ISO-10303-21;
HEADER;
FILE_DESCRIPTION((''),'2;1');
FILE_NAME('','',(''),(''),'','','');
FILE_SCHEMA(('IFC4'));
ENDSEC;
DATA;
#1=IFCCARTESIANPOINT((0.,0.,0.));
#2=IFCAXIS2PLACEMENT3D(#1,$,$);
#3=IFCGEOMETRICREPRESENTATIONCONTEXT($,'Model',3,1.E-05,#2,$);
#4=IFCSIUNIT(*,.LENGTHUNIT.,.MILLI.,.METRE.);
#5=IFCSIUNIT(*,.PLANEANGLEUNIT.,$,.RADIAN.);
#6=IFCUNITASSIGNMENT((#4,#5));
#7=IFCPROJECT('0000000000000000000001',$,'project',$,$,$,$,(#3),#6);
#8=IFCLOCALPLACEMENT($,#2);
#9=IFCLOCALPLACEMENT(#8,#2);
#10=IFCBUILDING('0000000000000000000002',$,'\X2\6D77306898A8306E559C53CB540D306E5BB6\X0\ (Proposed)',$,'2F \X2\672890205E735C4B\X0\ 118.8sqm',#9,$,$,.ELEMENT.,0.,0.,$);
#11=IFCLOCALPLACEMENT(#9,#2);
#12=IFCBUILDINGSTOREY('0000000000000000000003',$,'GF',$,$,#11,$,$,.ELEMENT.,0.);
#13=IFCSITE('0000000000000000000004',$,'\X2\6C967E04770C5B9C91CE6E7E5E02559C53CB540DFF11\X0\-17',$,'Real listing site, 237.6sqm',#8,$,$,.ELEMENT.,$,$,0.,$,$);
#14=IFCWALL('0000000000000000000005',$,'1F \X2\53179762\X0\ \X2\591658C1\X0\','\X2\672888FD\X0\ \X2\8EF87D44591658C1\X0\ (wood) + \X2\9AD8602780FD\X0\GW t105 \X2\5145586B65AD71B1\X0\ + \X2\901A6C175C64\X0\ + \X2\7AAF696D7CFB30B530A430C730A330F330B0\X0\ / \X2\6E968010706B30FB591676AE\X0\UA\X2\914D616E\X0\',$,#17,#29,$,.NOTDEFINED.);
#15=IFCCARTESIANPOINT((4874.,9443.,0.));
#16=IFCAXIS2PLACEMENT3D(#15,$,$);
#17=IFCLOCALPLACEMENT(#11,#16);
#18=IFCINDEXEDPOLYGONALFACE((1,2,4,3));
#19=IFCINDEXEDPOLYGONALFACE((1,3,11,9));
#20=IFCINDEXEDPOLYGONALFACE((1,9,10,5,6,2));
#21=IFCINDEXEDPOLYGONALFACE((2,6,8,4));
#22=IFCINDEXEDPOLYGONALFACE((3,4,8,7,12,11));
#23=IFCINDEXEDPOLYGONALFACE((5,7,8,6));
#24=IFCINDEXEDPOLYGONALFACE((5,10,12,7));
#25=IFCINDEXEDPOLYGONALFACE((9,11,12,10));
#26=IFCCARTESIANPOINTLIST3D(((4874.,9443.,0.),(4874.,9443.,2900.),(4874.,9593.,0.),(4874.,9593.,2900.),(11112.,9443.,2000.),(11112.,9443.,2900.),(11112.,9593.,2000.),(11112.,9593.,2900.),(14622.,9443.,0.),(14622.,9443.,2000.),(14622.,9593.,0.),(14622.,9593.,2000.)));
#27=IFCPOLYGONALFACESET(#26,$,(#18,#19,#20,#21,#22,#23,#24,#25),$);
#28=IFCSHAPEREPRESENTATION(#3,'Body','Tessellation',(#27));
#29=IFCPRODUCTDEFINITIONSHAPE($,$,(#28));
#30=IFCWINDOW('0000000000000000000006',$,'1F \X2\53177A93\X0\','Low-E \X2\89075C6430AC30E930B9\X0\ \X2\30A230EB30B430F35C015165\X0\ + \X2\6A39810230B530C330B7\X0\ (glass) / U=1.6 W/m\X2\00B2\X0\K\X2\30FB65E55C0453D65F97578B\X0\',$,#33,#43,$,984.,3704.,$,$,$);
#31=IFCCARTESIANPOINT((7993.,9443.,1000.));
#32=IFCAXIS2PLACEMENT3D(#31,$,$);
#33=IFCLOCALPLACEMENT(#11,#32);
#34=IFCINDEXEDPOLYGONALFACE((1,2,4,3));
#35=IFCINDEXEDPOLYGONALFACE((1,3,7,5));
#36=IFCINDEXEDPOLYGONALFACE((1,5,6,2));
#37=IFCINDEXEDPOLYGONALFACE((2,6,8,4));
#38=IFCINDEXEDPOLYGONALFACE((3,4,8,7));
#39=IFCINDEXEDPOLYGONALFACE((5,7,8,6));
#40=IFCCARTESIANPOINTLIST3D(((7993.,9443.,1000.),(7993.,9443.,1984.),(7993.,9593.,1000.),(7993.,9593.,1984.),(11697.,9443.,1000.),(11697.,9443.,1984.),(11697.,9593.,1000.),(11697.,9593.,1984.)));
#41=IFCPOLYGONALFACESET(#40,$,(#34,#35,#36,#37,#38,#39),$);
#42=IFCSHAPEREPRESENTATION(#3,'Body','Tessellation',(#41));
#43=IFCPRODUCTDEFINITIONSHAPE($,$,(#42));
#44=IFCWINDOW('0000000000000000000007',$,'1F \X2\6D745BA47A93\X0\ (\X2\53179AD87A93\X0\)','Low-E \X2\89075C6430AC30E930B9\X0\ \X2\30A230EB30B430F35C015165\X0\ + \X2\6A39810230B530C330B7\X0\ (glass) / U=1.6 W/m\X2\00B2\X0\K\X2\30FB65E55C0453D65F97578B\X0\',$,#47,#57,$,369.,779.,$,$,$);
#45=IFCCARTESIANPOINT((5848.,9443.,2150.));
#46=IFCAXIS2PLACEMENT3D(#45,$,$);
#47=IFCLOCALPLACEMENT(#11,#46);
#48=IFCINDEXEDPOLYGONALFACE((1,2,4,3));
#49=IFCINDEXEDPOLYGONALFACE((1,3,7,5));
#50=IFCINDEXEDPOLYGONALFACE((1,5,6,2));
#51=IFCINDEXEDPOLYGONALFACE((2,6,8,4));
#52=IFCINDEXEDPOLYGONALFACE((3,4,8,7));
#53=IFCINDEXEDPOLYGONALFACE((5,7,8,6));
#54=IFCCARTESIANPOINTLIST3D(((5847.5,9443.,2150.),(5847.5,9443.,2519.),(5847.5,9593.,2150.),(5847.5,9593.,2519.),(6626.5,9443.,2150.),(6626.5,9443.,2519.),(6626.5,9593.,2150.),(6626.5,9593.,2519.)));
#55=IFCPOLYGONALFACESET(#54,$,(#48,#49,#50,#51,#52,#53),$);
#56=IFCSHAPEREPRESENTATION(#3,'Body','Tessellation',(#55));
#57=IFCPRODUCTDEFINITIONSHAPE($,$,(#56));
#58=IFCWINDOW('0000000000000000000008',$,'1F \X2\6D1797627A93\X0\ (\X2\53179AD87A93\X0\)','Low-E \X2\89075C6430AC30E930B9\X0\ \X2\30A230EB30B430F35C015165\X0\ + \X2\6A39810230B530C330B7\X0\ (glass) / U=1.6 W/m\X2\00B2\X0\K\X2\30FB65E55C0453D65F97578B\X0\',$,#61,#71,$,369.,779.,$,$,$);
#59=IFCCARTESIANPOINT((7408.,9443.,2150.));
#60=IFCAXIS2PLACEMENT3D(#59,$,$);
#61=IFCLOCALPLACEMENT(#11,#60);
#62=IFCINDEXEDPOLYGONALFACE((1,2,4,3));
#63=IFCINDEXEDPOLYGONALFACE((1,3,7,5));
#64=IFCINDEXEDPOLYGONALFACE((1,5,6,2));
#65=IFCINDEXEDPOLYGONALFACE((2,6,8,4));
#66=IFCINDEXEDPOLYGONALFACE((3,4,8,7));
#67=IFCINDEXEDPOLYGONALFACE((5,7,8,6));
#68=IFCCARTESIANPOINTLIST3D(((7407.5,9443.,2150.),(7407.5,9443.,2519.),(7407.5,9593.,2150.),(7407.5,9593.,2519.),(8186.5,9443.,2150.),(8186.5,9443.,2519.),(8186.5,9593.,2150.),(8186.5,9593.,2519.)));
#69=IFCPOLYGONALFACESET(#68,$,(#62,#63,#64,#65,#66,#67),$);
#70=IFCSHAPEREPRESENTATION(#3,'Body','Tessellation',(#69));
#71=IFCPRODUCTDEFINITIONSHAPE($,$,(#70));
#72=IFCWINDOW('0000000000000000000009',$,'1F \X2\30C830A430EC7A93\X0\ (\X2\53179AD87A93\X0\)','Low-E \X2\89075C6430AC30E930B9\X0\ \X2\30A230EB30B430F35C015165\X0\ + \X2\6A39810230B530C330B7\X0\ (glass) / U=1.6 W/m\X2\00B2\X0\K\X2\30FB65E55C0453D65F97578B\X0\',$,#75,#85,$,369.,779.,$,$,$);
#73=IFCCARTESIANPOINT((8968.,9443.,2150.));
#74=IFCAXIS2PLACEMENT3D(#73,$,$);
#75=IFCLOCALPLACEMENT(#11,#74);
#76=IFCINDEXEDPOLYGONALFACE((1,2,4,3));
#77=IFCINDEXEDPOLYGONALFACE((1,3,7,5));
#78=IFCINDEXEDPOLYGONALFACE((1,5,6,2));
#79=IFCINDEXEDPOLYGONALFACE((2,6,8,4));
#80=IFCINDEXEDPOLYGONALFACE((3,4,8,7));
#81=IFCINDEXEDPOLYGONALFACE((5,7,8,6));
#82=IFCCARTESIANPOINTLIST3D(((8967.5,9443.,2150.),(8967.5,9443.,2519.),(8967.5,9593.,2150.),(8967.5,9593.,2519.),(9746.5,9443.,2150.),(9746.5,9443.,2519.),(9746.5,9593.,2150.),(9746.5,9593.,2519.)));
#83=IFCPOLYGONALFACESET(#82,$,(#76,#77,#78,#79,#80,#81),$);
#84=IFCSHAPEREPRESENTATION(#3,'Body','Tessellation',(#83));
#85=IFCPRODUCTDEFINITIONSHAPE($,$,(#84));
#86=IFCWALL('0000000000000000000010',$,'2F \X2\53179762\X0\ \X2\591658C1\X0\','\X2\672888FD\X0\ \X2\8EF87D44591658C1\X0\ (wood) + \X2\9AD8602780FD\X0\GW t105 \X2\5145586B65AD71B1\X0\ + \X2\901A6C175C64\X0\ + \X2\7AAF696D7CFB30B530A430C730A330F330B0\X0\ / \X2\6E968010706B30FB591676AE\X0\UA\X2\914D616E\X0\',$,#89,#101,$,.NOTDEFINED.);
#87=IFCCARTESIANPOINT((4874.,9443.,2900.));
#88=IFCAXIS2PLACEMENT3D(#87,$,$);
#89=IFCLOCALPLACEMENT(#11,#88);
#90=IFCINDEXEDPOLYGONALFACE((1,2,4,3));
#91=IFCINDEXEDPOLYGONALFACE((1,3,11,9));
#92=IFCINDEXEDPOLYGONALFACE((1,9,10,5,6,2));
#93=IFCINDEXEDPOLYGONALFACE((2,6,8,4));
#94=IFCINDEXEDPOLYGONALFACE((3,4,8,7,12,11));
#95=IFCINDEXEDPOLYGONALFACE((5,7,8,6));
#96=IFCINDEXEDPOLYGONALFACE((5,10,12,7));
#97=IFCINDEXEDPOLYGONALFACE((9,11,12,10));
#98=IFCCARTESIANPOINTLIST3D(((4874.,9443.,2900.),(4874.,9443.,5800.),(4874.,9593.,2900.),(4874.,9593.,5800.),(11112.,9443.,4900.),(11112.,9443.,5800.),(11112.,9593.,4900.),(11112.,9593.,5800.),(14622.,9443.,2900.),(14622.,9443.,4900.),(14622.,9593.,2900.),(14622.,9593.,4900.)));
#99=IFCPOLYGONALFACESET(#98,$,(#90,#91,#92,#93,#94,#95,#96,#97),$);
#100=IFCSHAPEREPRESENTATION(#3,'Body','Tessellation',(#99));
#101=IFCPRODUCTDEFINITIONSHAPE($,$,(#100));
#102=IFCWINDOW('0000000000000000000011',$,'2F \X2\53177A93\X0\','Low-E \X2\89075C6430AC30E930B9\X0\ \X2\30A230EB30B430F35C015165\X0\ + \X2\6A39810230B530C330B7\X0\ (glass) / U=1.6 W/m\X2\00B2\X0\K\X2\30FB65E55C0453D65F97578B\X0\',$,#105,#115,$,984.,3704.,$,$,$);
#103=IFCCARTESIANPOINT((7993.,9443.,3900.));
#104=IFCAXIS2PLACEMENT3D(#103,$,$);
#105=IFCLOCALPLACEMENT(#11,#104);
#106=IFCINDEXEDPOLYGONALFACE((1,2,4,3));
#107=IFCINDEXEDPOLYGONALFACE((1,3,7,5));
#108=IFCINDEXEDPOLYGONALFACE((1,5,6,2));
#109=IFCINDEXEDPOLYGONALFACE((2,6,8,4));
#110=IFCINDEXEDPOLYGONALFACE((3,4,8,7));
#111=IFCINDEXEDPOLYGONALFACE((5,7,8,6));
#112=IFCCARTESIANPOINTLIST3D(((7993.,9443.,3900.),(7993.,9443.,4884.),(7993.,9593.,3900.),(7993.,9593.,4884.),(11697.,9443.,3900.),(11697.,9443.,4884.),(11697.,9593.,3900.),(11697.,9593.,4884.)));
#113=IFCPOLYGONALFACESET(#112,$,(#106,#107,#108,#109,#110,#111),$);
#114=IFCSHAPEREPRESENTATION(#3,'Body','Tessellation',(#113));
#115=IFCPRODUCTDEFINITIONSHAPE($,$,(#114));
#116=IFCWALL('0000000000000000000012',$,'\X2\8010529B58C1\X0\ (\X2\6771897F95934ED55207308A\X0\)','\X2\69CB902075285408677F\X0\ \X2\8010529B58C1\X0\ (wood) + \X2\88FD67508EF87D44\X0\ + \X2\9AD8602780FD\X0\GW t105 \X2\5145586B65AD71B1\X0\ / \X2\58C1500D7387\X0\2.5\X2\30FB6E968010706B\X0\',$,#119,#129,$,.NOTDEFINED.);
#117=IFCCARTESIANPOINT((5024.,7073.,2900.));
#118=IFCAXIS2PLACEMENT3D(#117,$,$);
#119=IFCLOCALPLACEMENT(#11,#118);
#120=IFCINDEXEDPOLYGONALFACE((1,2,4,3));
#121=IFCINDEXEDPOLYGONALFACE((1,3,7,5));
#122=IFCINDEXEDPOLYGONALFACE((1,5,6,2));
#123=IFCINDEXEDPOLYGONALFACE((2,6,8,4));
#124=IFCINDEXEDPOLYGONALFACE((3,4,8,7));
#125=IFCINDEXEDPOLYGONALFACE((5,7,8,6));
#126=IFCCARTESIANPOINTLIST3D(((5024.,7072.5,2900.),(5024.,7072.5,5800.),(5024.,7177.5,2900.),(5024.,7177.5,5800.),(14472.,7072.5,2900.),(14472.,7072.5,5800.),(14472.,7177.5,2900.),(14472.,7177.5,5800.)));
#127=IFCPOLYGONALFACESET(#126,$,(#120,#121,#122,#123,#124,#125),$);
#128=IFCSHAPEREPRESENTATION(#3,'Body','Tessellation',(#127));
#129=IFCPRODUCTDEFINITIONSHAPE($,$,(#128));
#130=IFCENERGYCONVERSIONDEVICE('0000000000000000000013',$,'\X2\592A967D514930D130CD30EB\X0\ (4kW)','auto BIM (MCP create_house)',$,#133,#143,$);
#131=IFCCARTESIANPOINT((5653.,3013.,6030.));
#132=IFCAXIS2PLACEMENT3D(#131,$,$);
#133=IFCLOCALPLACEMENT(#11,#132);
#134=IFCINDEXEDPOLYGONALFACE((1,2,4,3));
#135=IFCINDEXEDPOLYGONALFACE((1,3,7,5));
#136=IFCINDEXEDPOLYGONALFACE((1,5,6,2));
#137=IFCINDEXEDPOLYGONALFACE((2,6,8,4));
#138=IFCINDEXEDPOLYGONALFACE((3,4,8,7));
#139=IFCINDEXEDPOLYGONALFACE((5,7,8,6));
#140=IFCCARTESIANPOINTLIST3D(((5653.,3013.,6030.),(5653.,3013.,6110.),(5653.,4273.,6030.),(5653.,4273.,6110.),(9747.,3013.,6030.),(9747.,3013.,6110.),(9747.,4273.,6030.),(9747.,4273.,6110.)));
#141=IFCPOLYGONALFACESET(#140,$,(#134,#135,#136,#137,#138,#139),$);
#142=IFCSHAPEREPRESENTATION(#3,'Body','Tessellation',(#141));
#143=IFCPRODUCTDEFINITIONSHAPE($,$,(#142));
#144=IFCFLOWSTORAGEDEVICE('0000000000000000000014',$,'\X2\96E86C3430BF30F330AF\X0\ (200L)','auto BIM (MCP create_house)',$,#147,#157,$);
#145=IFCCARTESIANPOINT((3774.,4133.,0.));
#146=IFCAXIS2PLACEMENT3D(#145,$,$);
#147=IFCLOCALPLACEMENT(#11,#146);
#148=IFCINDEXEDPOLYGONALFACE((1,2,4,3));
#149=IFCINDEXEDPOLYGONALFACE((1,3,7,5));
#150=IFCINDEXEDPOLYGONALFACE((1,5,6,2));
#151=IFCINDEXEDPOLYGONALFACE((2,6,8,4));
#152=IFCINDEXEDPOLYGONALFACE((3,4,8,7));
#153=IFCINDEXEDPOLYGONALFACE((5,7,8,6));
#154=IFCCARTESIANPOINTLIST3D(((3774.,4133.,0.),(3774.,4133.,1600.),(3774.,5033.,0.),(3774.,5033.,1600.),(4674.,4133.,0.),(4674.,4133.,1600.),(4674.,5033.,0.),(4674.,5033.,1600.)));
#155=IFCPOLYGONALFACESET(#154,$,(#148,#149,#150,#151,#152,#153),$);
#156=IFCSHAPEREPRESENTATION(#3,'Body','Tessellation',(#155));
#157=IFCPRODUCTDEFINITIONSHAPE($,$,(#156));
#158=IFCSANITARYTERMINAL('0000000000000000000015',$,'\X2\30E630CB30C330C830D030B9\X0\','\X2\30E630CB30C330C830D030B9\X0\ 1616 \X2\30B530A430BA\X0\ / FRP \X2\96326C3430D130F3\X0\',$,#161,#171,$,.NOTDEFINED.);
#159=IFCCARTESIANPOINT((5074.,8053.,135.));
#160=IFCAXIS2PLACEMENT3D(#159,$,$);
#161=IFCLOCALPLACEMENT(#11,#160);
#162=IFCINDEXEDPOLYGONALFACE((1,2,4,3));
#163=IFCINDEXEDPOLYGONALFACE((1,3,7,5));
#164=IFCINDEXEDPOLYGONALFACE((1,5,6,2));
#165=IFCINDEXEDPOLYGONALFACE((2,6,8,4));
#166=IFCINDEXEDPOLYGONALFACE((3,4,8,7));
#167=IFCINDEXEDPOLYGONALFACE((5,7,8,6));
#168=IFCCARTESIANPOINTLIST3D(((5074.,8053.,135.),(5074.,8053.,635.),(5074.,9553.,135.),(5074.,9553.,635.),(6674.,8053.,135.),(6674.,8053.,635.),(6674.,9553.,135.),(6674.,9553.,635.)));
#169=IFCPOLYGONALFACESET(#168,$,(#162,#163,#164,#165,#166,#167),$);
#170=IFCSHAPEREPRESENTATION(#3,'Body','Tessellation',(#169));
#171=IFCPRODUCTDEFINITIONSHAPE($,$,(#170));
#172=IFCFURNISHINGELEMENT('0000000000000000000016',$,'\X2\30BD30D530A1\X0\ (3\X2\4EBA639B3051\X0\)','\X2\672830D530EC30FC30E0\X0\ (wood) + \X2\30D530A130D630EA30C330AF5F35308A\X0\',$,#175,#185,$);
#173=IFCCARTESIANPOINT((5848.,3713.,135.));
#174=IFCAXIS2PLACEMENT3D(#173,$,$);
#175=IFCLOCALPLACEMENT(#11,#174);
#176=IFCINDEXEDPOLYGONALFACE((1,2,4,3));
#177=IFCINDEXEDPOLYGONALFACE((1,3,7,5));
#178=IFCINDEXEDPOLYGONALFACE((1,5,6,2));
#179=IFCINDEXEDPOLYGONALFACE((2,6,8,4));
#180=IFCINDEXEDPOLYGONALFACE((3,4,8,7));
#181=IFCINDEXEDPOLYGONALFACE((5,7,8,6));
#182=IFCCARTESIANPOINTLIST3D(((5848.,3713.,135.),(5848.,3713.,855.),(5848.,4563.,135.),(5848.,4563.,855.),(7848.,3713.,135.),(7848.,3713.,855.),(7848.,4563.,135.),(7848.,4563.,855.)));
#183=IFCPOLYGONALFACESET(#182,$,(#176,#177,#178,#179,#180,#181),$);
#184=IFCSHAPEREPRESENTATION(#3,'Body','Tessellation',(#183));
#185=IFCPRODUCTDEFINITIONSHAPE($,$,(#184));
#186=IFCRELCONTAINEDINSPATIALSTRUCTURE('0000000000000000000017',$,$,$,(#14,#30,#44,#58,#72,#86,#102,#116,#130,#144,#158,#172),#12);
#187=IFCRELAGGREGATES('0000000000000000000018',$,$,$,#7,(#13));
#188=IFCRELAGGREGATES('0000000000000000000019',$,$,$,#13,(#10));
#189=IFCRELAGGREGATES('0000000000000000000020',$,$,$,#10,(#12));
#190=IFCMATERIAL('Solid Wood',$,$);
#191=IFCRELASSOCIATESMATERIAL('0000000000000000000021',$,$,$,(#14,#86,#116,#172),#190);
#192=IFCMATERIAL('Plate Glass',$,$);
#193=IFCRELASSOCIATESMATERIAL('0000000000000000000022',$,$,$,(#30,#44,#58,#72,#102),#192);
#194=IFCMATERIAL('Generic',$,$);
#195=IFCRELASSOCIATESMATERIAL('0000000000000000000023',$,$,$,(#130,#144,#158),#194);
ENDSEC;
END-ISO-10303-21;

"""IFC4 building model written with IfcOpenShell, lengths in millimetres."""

from ifc_helpers import new_model, si_unit, frame, frame_2d, origin, place, context, project, spatial, rectangle, extrude, material, element, fill, save


model = new_model("IFC4")

# Units and contexts
model_context = context("Model", 3, precision=1e-05, world=origin())
ifc_project = project(units=[si_unit("LENGTHUNIT", "METRE", prefix="MILLI"), si_unit("PLANEANGLEUNIT", "RADIAN")], contexts=[model_context])

# Site, building, storey
site_placement = place(None, origin())
site = spatial("IfcSite", under=ifc_project, at=site_placement, Name="沖縄県宜野湾市喜友名１-17", ObjectType="Real listing site, 237.6sqm", CompositionType="ELEMENT", RefElevation=0.0)
building_placement = place(site_placement, origin())
building = spatial("IfcBuilding", under=site, at=building_placement, Name="海と風の喜友名の家 (Proposed)", ObjectType="2F 木造平屋 118.8sqm", CompositionType="ELEMENT", ElevationOfRefHeight=0.0, ElevationOfTerrain=0.0)
storey_placement = place(building_placement, origin())
storey = spatial("IfcBuildingStorey", under=building, at=storey_placement, Name="GF", CompositionType="ELEMENT", Elevation=0.0)

# Wall, openings, windows
ifc_material_1 = material(Name="Solid Wood")
wall_1_placement = place(storey_placement, frame((4874.0, 9443.0, 0.0)))
wall_1 = element("IfcWall", 1, at=wall_1_placement, inside=storey, material=ifc_material_1, Name="1F 北面 外壁", Description="木製 軸組外壁 (wood) + 高性能GW t105 充填断熱 + 通気層 + 窯業系サイディング / 準耐火・外皮UA配慮", PredefinedType="NOTDEFINED", context=model_context, shape_type="SweptSolid", body=[
    extrude(rectangle(XDim=9748.0, YDim=150.0, at=frame_2d((4874.0, 75.0))), frame((4874.0, 9443.0, 0.0)), (0.0, 0.0, 1.0), 2900.0),
])
opening_1_placement = place(storey_placement, frame((7993.0, 9443.0, 1000.0)))
opening_1 = element("IfcOpeningElement", 2, at=opening_1_placement, cuts=wall_1, PredefinedType="NOTDEFINED", context=model_context, shape_type="SweptSolid", body=[
    extrude(rectangle(XDim=3704.0, YDim=150.0, at=frame_2d((1852.0, 75.0))), frame((7993.0, 9443.0, 1000.0)), (0.0, 0.0, 1.0), 984.0),
])
opening_2_placement = place(storey_placement, frame((5848.0, 9443.0, 2150.0)))
opening_2 = element("IfcOpeningElement", 3, at=opening_2_placement, cuts=wall_1, PredefinedType="NOTDEFINED", context=model_context, shape_type="SweptSolid", body=[
    extrude(rectangle(XDim=779.0, YDim=150.0, at=frame_2d((389.0, 75.0))), frame((5848.0, 9443.0, 2150.0)), (0.0, 0.0, 1.0), 369.0),
])
opening_3_placement = place(storey_placement, frame((7408.0, 9443.0, 2150.0)))
opening_3 = element("IfcOpeningElement", 4, at=opening_3_placement, cuts=wall_1, PredefinedType="NOTDEFINED", context=model_context, shape_type="SweptSolid", body=[
    extrude(rectangle(XDim=779.0, YDim=150.0, at=frame_2d((389.0, 75.0))), frame((7408.0, 9443.0, 2150.0)), (0.0, 0.0, 1.0), 369.0),
])
opening_4_placement = place(storey_placement, frame((8968.0, 9443.0, 2150.0)))
opening_4 = element("IfcOpeningElement", 5, at=opening_4_placement, cuts=wall_1, PredefinedType="NOTDEFINED", context=model_context, shape_type="SweptSolid", body=[
    extrude(rectangle(XDim=779.0, YDim=150.0, at=frame_2d((389.0, 75.0))), frame((8968.0, 9443.0, 2150.0)), (0.0, 0.0, 1.0), 369.0),
])
ifc_material_2 = material(Name="Plate Glass")
window_1_placement = place(storey_placement, frame((7993.0, 9443.0, 1000.0)))
window_1 = element("IfcWindow", 6, at=window_1_placement, inside=storey, material=ifc_material_2, Name="1F 北窓", Description="Low-E 複層ガラス アルゴン封入 + 樹脂サッシ (glass) / U=1.6 W/m²K・日射取得型", OverallHeight=984.0, OverallWidth=3704.0, context=model_context, shape_type="SweptSolid", body=[
    extrude(rectangle(XDim=3704.0, YDim=150.0, at=frame_2d((1852.0, 75.0))), frame((7993.0, 9443.0, 1000.0)), (0.0, 0.0, 1.0), 984.0),
])
fill(opening_1, window_1)
window_2_placement = place(storey_placement, frame((5848.0, 9443.0, 2150.0)))
window_2 = element("IfcWindow", 7, at=window_2_placement, inside=storey, material=ifc_material_2, Name="1F 浴室窓 (北高窓)", Description="Low-E 複層ガラス アルゴン封入 + 樹脂サッシ (glass) / U=1.6 W/m²K・日射取得型", OverallHeight=369.0, OverallWidth=779.0, context=model_context, shape_type="SweptSolid", body=[
    extrude(rectangle(XDim=779.0, YDim=150.0, at=frame_2d((389.0, 75.0))), frame((5848.0, 9443.0, 2150.0)), (0.0, 0.0, 1.0), 369.0),
])
fill(opening_2, window_2)
window_3_placement = place(storey_placement, frame((7408.0, 9443.0, 2150.0)))
window_3 = element("IfcWindow", 8, at=window_3_placement, inside=storey, material=ifc_material_2, Name="1F 洗面窓 (北高窓)", Description="Low-E 複層ガラス アルゴン封入 + 樹脂サッシ (glass) / U=1.6 W/m²K・日射取得型", OverallHeight=369.0, OverallWidth=779.0, context=model_context, shape_type="SweptSolid", body=[
    extrude(rectangle(XDim=779.0, YDim=150.0, at=frame_2d((389.0, 75.0))), frame((7408.0, 9443.0, 2150.0)), (0.0, 0.0, 1.0), 369.0),
])
fill(opening_3, window_3)
window_4_placement = place(storey_placement, frame((8968.0, 9443.0, 2150.0)))
window_4 = element("IfcWindow", 9, at=window_4_placement, inside=storey, material=ifc_material_2, Name="1F トイレ窓 (北高窓)", Description="Low-E 複層ガラス アルゴン封入 + 樹脂サッシ (glass) / U=1.6 W/m²K・日射取得型", OverallHeight=369.0, OverallWidth=779.0, context=model_context, shape_type="SweptSolid", body=[
    extrude(rectangle(XDim=779.0, YDim=150.0, at=frame_2d((389.0, 75.0))), frame((8968.0, 9443.0, 2150.0)), (0.0, 0.0, 1.0), 369.0),
])
fill(opening_4, window_4)

# Wall, opening, window
wall_2_placement = place(storey_placement, frame((4874.0, 9443.0, 2900.0)))
wall_2 = element("IfcWall", 10, at=wall_2_placement, inside=storey, material=ifc_material_1, Name="2F 北面 外壁", Description="木製 軸組外壁 (wood) + 高性能GW t105 充填断熱 + 通気層 + 窯業系サイディング / 準耐火・外皮UA配慮", PredefinedType="NOTDEFINED", context=model_context, shape_type="SweptSolid", body=[
    extrude(rectangle(XDim=9748.0, YDim=150.0, at=frame_2d((4874.0, 75.0))), frame((4874.0, 9443.0, 2900.0)), (0.0, 0.0, 1.0), 2900.0),
])
opening_5_placement = place(storey_placement, frame((7993.0, 9443.0, 3900.0)))
opening_5 = element("IfcOpeningElement", 11, at=opening_5_placement, cuts=wall_2, PredefinedType="NOTDEFINED", context=model_context, shape_type="SweptSolid", body=[
    extrude(rectangle(XDim=3704.0, YDim=150.0, at=frame_2d((1852.0, 75.0))), frame((7993.0, 9443.0, 3900.0)), (0.0, 0.0, 1.0), 984.0),
])
window_5_placement = place(storey_placement, frame((7993.0, 9443.0, 3900.0)))
window_5 = element("IfcWindow", 12, at=window_5_placement, inside=storey, material=ifc_material_2, Name="2F 北窓", Description="Low-E 複層ガラス アルゴン封入 + 樹脂サッシ (glass) / U=1.6 W/m²K・日射取得型", OverallHeight=984.0, OverallWidth=3704.0, context=model_context, shape_type="SweptSolid", body=[
    extrude(rectangle(XDim=3704.0, YDim=150.0, at=frame_2d((1852.0, 75.0))), frame((7993.0, 9443.0, 3900.0)), (0.0, 0.0, 1.0), 984.0),
])
fill(opening_5, window_5)

# Wall
wall_3_placement = place(storey_placement, frame((5024.0, 7073.0, 2900.0)))
element("IfcWall", 13, at=wall_3_placement, inside=storey, material=ifc_material_1, Name="耐力壁 (東西間仕切り)", Description="構造用合板 耐力壁 (wood) + 製材軸組 + 高性能GW t105 充填断熱 / 壁倍率2.5・準耐火", PredefinedType="NOTDEFINED", context=model_context, shape_type="SweptSolid", body=[
    extrude(rectangle(XDim=9448.0, YDim=105.0, at=frame_2d((4724.0, 52.0))), frame((5024.0, 7073.0, 2900.0)), (0.0, 0.0, 1.0), 2900.0),
])

# Energy conversion device
ifc_material_3 = material(Name="Generic")
energy_conversion_device_placement = place(storey_placement, frame((5653.0, 3013.0, 6030.0)))
element("IfcEnergyConversionDevice", 14, at=energy_conversion_device_placement, inside=storey, material=ifc_material_3, Name="太陽光パネル (4kW)", Description="auto BIM (MCP create_house)", context=model_context, shape_type="SweptSolid", body=[
    extrude(rectangle(XDim=4094.0, YDim=1260.0, at=frame_2d((2047.0, 630.0))), frame((5653.0, 3013.0, 6030.0)), (0.0, 0.0, 1.0), 80.0),
])

# Flow storage device
flow_storage_device_placement = place(storey_placement, frame((3774.0, 4133.0, 0.0)))
element("IfcFlowStorageDevice", 15, at=flow_storage_device_placement, inside=storey, material=ifc_material_3, Name="雨水タンク (200L)", Description="auto BIM (MCP create_house)", context=model_context, shape_type="SweptSolid", body=[
    extrude(rectangle(XDim=900.0, YDim=900.0, at=frame_2d((450.0, 450.0))), frame((3774.0, 4133.0, 0.0)), (0.0, 0.0, 1.0), 1600.0),
])

# Sanitary terminal
sanitary_terminal_placement = place(storey_placement, frame((5074.0, 8053.0, 135.0)))
element("IfcSanitaryTerminal", 16, at=sanitary_terminal_placement, inside=storey, material=ifc_material_3, Name="ユニットバス", Description="ユニットバス 1616 サイズ / FRP 防水パン", PredefinedType="NOTDEFINED", context=model_context, shape_type="SweptSolid", body=[
    extrude(rectangle(XDim=1600.0, YDim=1500.0, at=frame_2d((800.0, 750.0))), frame((5074.0, 8053.0, 135.0)), (0.0, 0.0, 1.0), 500.0),
])

# Furnishing element
furnishing_1_placement = place(storey_placement, frame((5848.0, 3713.0, 135.0)))
element("IfcFurnishingElement", 17, at=furnishing_1_placement, inside=storey, material=ifc_material_1, Name="ソファ (3人掛け)", Description="木フレーム (wood) + ファブリック張り", context=model_context, shape_type="SweptSolid", body=[
    extrude(rectangle(XDim=2000.0, YDim=850.0, at=frame_2d((1000.0, 425.0))), frame((5848.0, 3713.0, 135.0)), (0.0, 0.0, 1.0), 720.0),
])

save(model, "model.ifc")
